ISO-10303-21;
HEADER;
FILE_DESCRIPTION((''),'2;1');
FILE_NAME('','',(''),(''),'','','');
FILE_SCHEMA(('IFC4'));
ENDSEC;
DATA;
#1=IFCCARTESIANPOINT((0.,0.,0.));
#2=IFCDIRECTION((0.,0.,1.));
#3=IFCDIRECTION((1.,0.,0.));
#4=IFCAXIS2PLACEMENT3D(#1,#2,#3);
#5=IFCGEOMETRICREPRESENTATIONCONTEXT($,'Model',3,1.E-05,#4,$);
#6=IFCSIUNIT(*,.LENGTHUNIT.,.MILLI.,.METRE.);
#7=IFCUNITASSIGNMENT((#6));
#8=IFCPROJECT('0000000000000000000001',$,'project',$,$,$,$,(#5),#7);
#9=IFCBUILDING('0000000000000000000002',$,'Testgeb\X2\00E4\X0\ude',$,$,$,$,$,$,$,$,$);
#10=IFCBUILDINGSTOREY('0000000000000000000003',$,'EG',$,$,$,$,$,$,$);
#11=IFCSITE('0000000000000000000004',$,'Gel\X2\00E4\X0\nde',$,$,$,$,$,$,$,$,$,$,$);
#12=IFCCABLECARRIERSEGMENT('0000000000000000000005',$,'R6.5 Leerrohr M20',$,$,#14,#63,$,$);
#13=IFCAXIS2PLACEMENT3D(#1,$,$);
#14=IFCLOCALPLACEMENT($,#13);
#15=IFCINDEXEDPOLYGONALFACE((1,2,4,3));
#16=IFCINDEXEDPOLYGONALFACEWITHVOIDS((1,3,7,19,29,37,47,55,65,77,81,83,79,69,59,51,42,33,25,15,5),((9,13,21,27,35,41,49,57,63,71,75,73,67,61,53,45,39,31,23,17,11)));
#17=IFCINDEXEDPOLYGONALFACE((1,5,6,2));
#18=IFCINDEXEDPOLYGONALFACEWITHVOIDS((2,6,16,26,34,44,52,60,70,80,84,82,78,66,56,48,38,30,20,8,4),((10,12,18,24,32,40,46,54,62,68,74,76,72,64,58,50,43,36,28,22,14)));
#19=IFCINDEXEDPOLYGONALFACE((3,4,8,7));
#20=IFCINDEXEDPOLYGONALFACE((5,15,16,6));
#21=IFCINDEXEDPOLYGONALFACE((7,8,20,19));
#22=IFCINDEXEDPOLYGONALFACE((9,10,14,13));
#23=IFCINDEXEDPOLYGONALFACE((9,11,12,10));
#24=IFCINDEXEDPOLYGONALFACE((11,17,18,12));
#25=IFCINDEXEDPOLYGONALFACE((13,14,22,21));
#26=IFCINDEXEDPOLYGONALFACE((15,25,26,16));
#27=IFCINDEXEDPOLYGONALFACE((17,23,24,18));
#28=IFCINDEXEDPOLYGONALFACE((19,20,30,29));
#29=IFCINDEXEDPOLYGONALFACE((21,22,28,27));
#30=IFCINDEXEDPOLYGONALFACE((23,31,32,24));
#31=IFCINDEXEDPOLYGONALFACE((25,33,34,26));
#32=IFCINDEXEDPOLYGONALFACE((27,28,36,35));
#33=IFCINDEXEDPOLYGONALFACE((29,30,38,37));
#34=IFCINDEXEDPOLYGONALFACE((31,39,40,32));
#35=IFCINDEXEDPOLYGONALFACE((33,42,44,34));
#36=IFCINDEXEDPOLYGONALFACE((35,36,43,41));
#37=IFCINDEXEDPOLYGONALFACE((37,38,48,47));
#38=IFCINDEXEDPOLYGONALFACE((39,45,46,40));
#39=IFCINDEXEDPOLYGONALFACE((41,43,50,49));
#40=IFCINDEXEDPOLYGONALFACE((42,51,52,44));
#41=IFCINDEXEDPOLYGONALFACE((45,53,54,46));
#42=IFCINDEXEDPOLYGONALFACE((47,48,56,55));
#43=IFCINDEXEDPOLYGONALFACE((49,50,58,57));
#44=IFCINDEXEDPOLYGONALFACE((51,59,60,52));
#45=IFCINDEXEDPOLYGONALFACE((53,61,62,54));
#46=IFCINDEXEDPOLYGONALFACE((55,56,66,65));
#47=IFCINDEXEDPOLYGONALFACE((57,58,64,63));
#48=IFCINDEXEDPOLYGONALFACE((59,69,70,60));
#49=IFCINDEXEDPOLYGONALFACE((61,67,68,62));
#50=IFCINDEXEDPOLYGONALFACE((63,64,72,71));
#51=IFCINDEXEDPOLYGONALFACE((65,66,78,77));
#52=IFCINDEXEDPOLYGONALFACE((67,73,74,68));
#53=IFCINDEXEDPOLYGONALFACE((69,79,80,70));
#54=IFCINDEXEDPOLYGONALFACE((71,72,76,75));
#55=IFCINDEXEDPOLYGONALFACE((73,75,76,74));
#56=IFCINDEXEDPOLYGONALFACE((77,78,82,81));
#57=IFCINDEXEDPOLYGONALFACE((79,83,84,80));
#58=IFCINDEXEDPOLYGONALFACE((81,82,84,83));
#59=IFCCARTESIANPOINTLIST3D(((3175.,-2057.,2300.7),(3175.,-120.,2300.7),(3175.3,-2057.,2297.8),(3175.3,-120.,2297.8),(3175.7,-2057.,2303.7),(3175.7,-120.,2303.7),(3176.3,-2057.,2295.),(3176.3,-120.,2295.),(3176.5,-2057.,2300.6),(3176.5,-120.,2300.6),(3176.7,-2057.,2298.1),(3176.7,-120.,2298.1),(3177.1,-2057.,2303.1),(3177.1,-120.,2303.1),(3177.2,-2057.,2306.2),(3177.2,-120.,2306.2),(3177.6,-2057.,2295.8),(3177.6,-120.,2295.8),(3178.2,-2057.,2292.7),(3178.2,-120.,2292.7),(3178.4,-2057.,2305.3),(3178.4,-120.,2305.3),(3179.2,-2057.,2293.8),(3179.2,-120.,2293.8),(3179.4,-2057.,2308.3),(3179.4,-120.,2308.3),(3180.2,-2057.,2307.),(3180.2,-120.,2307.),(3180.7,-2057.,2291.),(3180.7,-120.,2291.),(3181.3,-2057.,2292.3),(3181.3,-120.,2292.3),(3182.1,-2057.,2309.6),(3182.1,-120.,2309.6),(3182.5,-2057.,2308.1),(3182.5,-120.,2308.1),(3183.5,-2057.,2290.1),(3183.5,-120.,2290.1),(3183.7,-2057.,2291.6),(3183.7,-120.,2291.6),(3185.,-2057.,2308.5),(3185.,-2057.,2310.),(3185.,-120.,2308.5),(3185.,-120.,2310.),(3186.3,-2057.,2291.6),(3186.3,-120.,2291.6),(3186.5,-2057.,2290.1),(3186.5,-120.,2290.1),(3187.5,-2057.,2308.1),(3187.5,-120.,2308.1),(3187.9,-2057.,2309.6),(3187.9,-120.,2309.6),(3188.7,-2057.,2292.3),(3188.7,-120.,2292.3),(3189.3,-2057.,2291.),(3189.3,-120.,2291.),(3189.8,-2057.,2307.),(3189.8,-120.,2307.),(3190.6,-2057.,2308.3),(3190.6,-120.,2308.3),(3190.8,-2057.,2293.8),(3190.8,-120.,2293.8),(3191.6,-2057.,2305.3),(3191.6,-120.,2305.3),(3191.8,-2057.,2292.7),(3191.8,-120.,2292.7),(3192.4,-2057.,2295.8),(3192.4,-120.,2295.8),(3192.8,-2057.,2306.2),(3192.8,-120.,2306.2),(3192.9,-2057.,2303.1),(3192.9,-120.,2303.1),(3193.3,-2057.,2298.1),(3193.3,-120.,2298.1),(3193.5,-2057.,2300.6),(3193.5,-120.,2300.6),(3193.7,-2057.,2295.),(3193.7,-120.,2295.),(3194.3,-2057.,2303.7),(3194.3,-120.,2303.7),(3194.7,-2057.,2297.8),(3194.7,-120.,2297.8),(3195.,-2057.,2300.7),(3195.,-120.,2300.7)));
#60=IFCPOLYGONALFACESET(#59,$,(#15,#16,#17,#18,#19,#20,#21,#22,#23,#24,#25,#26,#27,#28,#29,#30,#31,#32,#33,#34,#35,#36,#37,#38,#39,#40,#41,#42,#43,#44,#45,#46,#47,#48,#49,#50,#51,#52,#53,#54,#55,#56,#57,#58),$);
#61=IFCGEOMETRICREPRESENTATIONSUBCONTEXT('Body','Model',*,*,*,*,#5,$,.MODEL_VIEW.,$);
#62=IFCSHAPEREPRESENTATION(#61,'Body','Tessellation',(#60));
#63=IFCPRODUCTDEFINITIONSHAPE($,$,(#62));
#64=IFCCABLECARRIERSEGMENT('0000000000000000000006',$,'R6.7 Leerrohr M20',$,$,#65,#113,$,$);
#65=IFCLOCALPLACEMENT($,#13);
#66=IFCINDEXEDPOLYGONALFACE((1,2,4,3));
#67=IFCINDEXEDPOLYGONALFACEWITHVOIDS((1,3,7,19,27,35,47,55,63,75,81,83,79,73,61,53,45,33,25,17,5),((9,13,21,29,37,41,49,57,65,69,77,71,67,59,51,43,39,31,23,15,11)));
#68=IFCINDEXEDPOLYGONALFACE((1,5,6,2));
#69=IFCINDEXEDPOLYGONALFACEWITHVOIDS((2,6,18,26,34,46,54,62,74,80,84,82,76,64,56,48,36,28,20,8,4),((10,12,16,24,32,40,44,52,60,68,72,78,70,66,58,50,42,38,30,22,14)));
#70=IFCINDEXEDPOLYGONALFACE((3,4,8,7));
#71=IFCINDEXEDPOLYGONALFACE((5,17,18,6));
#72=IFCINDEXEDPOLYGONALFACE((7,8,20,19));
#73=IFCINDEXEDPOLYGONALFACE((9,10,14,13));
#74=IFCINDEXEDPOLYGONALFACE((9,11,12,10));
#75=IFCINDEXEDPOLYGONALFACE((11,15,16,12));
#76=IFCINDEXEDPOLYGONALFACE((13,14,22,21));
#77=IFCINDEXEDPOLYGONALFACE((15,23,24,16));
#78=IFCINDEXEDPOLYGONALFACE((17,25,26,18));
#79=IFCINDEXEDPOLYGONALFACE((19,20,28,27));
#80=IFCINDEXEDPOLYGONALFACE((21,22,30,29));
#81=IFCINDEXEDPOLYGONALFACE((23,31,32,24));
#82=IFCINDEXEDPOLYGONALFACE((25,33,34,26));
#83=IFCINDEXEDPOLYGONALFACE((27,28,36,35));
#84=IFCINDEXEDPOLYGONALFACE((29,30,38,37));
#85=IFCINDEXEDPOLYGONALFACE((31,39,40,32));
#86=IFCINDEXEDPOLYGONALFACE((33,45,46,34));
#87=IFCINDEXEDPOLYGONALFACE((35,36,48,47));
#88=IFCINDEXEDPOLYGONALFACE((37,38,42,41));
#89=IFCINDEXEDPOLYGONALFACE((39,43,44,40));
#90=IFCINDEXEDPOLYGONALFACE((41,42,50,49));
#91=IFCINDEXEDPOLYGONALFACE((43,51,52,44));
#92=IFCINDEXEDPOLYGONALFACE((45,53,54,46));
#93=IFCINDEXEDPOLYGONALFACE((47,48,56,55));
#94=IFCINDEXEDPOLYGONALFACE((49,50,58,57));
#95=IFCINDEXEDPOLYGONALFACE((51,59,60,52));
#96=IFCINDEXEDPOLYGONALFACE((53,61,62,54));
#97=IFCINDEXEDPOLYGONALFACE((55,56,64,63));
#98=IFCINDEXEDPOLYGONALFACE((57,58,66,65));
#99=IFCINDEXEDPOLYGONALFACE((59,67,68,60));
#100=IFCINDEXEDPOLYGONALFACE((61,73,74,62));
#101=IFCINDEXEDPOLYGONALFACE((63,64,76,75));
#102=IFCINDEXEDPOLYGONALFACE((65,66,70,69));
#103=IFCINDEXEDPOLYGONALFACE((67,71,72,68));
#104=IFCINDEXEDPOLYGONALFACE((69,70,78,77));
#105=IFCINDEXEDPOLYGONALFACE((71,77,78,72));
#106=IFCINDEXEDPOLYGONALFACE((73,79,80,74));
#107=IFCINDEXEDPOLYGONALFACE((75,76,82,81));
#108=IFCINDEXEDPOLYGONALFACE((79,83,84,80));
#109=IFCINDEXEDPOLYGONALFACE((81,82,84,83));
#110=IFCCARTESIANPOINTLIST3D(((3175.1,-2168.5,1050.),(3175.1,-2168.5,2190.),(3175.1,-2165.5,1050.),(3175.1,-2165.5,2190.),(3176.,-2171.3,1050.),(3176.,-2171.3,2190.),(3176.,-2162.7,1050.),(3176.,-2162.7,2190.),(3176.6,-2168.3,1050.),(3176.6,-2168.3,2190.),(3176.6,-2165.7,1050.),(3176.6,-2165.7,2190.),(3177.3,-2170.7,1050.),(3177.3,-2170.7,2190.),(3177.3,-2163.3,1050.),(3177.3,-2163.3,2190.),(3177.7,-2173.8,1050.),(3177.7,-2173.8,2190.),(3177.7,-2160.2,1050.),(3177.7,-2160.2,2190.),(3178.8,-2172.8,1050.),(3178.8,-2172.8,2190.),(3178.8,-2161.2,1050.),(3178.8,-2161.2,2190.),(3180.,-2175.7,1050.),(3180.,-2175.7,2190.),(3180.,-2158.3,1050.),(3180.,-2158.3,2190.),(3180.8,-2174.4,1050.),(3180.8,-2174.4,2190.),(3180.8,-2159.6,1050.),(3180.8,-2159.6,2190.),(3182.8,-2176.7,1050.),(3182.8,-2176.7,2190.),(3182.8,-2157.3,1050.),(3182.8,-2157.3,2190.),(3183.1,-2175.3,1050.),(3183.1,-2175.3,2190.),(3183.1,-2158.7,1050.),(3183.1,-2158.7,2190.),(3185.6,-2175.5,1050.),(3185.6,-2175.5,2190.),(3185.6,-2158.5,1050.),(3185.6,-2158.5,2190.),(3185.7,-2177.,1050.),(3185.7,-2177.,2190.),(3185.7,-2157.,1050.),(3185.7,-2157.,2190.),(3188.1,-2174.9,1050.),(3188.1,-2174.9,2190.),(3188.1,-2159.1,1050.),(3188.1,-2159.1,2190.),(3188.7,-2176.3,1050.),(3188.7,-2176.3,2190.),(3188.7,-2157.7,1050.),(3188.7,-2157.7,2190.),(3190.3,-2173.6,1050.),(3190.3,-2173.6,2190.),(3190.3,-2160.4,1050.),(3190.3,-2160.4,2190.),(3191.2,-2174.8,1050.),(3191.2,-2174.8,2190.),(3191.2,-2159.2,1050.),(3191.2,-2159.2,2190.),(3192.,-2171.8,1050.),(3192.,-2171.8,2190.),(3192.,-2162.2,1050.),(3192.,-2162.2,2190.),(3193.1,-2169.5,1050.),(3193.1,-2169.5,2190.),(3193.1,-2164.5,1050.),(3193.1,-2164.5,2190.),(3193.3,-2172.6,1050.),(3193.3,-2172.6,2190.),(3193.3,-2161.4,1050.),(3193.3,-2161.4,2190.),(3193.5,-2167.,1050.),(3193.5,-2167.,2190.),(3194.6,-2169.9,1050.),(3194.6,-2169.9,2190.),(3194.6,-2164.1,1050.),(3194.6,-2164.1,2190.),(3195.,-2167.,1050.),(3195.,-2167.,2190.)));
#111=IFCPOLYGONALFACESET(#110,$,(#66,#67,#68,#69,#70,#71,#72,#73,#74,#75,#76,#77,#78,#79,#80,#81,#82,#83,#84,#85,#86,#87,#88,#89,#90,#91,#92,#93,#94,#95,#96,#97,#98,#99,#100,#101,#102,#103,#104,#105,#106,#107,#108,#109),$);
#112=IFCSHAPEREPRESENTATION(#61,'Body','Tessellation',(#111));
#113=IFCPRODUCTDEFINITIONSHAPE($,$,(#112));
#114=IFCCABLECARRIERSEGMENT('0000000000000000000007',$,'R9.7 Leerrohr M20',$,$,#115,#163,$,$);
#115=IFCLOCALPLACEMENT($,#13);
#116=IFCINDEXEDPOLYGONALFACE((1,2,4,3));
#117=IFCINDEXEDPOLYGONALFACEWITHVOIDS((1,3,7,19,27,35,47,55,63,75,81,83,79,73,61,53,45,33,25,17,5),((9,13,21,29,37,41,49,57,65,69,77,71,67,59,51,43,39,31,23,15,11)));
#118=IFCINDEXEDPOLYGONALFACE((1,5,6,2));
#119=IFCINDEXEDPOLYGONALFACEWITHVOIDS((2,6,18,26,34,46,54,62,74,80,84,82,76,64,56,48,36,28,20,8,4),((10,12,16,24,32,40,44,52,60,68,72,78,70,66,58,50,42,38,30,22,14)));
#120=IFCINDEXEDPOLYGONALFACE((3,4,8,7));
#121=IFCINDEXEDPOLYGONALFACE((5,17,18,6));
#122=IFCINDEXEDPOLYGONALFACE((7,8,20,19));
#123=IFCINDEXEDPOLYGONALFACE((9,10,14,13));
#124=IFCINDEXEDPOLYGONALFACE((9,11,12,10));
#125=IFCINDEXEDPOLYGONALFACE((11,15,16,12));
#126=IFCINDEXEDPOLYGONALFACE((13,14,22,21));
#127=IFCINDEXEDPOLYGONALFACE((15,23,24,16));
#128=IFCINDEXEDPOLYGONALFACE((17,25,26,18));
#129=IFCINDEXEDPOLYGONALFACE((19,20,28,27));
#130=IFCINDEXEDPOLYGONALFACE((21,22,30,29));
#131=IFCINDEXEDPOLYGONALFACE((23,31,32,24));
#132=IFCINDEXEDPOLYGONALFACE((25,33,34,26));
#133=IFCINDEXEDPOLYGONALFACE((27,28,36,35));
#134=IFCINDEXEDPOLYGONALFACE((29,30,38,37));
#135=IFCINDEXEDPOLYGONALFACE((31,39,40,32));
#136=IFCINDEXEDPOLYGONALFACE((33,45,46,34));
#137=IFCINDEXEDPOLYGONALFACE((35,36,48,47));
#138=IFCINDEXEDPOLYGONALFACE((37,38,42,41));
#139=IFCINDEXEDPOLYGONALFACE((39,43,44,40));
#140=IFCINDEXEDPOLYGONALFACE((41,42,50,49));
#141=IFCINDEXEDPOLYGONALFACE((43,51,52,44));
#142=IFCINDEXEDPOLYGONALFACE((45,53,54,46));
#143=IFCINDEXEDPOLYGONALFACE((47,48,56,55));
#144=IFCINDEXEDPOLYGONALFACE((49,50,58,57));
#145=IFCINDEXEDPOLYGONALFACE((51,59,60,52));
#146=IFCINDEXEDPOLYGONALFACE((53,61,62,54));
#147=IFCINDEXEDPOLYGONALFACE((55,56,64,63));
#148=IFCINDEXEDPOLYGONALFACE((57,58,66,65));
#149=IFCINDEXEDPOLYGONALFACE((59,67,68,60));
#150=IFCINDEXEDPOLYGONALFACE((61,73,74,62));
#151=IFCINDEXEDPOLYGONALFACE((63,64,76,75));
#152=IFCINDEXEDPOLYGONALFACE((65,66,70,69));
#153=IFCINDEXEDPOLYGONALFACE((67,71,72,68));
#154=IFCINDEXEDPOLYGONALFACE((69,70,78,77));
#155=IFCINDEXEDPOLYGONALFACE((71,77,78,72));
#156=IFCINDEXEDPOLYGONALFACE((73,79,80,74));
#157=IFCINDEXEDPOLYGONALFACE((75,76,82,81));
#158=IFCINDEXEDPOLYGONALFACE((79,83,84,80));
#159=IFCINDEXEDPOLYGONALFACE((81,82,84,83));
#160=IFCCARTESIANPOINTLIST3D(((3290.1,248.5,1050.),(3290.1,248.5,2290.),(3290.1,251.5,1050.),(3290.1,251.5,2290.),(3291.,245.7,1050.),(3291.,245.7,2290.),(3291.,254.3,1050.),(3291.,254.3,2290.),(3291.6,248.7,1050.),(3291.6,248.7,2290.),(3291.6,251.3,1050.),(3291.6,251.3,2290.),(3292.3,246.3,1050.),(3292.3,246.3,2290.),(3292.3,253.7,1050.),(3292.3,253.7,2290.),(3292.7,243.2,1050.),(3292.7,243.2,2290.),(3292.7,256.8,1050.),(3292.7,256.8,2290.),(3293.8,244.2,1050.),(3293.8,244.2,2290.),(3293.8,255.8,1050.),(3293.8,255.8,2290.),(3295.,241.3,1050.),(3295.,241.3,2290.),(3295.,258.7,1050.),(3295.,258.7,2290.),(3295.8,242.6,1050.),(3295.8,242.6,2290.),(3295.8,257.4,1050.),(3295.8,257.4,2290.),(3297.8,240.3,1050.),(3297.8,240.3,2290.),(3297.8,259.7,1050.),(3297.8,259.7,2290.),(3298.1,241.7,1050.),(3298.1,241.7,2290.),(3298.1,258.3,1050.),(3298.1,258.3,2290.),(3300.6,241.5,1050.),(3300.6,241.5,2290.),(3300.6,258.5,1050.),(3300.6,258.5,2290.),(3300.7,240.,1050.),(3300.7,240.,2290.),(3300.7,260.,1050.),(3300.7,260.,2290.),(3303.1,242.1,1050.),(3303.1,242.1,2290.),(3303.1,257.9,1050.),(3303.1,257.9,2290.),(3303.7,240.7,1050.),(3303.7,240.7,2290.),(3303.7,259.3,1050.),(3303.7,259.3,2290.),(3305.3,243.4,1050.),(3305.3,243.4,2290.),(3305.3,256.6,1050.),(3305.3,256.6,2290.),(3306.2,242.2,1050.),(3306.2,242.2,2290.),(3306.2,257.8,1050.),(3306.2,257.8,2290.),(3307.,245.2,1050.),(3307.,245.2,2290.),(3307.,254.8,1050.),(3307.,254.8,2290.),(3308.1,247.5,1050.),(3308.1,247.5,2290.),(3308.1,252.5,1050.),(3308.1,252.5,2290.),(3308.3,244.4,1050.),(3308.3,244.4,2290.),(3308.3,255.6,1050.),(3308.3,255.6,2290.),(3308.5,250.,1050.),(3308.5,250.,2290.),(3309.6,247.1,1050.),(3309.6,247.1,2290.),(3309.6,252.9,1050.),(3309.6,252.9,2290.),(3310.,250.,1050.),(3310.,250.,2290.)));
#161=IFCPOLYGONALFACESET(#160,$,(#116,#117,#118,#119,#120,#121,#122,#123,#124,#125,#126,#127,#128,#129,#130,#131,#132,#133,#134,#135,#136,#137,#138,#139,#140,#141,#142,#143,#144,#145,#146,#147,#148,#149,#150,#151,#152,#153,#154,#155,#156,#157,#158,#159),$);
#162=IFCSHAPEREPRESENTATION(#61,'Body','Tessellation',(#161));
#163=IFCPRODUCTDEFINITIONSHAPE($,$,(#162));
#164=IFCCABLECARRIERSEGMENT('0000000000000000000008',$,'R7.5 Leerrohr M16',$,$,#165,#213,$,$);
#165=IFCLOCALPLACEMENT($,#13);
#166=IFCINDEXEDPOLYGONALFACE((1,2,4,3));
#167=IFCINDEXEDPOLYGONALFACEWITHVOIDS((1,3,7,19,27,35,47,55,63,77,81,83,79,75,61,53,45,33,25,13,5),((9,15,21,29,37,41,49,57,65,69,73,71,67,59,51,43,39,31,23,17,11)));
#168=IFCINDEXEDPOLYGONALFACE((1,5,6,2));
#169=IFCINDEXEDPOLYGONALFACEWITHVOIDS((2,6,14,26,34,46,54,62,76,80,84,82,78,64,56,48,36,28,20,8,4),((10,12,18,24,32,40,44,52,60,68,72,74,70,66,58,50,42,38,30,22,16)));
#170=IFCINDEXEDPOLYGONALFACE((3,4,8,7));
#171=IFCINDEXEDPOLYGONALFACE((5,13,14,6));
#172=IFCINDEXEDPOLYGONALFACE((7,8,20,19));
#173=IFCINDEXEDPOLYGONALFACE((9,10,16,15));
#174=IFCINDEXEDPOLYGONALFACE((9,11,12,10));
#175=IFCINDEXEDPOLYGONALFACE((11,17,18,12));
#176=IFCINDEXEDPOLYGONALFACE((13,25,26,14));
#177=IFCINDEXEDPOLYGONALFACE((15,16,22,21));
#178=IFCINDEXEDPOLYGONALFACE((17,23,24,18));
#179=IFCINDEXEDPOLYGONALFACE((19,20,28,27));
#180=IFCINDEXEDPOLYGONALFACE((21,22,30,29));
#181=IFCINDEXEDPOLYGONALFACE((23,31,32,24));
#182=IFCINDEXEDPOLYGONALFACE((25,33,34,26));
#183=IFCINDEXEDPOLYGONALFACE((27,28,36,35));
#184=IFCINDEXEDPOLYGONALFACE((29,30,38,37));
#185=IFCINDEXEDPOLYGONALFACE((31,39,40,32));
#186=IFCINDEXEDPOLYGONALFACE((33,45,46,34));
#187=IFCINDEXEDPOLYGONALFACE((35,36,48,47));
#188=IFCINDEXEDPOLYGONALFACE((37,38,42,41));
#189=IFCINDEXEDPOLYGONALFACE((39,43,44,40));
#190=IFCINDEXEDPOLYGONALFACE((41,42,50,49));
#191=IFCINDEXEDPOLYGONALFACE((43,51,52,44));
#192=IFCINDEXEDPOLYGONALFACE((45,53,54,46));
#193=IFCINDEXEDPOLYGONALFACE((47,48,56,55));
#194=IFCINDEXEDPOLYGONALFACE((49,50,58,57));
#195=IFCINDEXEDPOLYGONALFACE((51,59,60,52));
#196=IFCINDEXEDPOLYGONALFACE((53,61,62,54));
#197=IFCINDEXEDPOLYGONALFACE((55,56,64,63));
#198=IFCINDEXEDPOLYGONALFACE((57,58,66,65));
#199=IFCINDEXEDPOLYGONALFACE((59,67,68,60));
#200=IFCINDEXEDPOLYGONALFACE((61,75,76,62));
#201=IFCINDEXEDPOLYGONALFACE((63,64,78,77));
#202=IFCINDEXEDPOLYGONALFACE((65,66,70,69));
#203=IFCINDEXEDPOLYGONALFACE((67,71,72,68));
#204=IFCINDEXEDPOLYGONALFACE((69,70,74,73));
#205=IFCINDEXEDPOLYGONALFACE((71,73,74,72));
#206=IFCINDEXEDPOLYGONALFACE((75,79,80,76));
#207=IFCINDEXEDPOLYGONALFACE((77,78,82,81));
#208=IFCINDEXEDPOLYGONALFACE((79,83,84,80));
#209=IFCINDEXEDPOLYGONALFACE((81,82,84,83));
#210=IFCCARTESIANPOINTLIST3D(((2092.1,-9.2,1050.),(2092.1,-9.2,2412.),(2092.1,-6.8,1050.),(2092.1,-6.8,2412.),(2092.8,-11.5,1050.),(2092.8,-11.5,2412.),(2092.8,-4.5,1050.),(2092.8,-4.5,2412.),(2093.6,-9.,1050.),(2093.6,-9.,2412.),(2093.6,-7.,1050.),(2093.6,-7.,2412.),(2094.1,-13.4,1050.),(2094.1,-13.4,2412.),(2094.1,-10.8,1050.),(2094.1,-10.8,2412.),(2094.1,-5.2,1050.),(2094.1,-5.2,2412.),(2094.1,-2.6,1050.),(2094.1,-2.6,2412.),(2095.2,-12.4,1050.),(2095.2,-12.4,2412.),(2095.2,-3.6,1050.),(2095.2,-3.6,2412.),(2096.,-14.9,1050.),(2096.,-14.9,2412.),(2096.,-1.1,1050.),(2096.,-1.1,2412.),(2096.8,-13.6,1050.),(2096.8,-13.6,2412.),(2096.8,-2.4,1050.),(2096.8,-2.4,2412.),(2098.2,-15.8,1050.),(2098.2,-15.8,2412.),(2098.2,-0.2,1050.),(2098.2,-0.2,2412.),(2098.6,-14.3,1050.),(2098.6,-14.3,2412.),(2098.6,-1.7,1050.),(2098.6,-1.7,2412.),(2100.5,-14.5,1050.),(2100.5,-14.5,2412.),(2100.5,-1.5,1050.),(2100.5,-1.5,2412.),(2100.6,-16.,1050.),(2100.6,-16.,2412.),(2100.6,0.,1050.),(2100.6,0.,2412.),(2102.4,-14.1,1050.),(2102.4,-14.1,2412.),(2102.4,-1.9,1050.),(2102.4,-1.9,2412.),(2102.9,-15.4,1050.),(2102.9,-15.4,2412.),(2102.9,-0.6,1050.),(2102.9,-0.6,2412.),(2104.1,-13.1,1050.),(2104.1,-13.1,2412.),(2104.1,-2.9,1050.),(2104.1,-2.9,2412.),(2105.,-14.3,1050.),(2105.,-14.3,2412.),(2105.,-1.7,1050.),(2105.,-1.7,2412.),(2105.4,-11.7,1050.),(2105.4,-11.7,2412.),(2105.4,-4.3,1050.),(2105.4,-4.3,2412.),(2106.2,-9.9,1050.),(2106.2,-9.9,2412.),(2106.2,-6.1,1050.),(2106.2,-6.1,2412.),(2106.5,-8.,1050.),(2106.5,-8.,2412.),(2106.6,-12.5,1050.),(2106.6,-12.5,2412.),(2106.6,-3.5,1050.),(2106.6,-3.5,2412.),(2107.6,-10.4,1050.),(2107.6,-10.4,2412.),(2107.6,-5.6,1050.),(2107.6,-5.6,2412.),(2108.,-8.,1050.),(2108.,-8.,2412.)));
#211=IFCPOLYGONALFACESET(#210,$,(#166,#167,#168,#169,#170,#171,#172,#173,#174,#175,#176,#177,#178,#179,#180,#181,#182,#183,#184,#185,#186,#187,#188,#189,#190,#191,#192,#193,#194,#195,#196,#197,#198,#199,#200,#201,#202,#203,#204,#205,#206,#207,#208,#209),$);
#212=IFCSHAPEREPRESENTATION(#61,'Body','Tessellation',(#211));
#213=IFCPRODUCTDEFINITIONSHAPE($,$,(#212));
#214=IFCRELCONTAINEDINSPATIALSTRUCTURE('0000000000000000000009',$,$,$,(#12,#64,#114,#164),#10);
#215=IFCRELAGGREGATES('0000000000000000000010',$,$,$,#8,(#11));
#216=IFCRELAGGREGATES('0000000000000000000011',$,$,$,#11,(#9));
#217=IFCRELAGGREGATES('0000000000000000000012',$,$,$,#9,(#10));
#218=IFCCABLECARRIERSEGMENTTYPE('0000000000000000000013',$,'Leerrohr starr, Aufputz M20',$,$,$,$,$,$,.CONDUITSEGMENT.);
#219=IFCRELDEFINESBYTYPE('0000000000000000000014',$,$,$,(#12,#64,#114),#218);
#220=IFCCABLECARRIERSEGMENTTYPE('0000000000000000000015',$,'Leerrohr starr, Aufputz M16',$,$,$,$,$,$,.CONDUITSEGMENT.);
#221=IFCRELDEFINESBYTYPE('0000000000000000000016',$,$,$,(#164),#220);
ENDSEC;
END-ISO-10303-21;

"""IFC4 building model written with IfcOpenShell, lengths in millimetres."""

from ifc_helpers import new_model, si_unit, frame, origin_with_axes, place, context, subcontext, project, spatial, hollow_circle, extrude, type_object, element, save


model = new_model("IFC4")

# Units and contexts
model_context = context("Model", 3, precision=1e-05, world=origin_with_axes())
body_context = subcontext(model_context, "Body", "Model", "MODEL_VIEW")
ifc_project = project(units=[si_unit("LENGTHUNIT", "METRE", prefix="MILLI")], contexts=[model_context])

# Site, building, storey
site = spatial("IfcSite", under=ifc_project, Name="Gelände")
building = spatial("IfcBuilding", under=site, Name="Testgebäude")
storey = spatial("IfcBuildingStorey", under=building, Name="EG")

# Cable carrier segments
cable_carrier_segment_type_1 = type_object("IfcCableCarrierSegmentType", Name="Leerrohr starr, Aufputz M20", PredefinedType="CONDUITSEGMENT")
cable_carrier_segment_1_placement = place(None, frame((3185.0, -120.0, 2300.0), z_axis=(0.0, -1.0, 0.0), x_axis=(0.0, 0.0, 1.0)))
element("IfcCableCarrierSegment", 1, at=cable_carrier_segment_1_placement, inside=storey, type_object=cable_carrier_segment_type_1, Name="R6.5 Leerrohr M20", context=body_context, shape_type="SweptSolid", body=[
    extrude(hollow_circle(Radius=10.0, WallThickness=1.5), None, (0.0, 0.0, 1.0), 1937.0),
])
cable_carrier_segment_2_placement = place(None, frame((3185.0, -2167.0, 2190.0), z_axis=(0.0, 0.0, -1.0), x_axis=(1.0, 0.0, 0.0)))
element("IfcCableCarrierSegment", 2, at=cable_carrier_segment_2_placement, inside=storey, type_object=cable_carrier_segment_type_1, Name="R6.7 Leerrohr M20", context=body_context, shape_type="SweptSolid", body=[
    extrude(hollow_circle(Radius=10.0, WallThickness=1.5), None, (0.0, 0.0, 1.0), 1140.0),
])
cable_carrier_segment_3_placement = place(None, frame((3300.0, 250.0, 2290.0), z_axis=(0.0, 0.0, -1.0), x_axis=(1.0, 0.0, 0.0)))
element("IfcCableCarrierSegment", 3, at=cable_carrier_segment_3_placement, inside=storey, type_object=cable_carrier_segment_type_1, Name="R9.7 Leerrohr M20", context=body_context, shape_type="SweptSolid", body=[
    extrude(hollow_circle(Radius=10.0, WallThickness=1.5), None, (0.0, 0.0, 1.0), 1240.0),
])

# Cable carrier segment
cable_carrier_segment_type_2 = type_object("IfcCableCarrierSegmentType", Name="Leerrohr starr, Aufputz M16", PredefinedType="CONDUITSEGMENT")
cable_carrier_segment_4_placement = place(None, frame((2100.0, -8.0, 2412.0), z_axis=(0.0, 0.0, -1.0), x_axis=(1.0, 0.0, 0.0)))
element("IfcCableCarrierSegment", 4, at=cable_carrier_segment_4_placement, inside=storey, type_object=cable_carrier_segment_type_2, Name="R7.5 Leerrohr M16", context=body_context, shape_type="SweptSolid", body=[
    extrude(hollow_circle(Radius=8.0, WallThickness=1.5), None, (0.0, 0.0, 1.0), 1362.0),
])

save(model, "model.ifc")
